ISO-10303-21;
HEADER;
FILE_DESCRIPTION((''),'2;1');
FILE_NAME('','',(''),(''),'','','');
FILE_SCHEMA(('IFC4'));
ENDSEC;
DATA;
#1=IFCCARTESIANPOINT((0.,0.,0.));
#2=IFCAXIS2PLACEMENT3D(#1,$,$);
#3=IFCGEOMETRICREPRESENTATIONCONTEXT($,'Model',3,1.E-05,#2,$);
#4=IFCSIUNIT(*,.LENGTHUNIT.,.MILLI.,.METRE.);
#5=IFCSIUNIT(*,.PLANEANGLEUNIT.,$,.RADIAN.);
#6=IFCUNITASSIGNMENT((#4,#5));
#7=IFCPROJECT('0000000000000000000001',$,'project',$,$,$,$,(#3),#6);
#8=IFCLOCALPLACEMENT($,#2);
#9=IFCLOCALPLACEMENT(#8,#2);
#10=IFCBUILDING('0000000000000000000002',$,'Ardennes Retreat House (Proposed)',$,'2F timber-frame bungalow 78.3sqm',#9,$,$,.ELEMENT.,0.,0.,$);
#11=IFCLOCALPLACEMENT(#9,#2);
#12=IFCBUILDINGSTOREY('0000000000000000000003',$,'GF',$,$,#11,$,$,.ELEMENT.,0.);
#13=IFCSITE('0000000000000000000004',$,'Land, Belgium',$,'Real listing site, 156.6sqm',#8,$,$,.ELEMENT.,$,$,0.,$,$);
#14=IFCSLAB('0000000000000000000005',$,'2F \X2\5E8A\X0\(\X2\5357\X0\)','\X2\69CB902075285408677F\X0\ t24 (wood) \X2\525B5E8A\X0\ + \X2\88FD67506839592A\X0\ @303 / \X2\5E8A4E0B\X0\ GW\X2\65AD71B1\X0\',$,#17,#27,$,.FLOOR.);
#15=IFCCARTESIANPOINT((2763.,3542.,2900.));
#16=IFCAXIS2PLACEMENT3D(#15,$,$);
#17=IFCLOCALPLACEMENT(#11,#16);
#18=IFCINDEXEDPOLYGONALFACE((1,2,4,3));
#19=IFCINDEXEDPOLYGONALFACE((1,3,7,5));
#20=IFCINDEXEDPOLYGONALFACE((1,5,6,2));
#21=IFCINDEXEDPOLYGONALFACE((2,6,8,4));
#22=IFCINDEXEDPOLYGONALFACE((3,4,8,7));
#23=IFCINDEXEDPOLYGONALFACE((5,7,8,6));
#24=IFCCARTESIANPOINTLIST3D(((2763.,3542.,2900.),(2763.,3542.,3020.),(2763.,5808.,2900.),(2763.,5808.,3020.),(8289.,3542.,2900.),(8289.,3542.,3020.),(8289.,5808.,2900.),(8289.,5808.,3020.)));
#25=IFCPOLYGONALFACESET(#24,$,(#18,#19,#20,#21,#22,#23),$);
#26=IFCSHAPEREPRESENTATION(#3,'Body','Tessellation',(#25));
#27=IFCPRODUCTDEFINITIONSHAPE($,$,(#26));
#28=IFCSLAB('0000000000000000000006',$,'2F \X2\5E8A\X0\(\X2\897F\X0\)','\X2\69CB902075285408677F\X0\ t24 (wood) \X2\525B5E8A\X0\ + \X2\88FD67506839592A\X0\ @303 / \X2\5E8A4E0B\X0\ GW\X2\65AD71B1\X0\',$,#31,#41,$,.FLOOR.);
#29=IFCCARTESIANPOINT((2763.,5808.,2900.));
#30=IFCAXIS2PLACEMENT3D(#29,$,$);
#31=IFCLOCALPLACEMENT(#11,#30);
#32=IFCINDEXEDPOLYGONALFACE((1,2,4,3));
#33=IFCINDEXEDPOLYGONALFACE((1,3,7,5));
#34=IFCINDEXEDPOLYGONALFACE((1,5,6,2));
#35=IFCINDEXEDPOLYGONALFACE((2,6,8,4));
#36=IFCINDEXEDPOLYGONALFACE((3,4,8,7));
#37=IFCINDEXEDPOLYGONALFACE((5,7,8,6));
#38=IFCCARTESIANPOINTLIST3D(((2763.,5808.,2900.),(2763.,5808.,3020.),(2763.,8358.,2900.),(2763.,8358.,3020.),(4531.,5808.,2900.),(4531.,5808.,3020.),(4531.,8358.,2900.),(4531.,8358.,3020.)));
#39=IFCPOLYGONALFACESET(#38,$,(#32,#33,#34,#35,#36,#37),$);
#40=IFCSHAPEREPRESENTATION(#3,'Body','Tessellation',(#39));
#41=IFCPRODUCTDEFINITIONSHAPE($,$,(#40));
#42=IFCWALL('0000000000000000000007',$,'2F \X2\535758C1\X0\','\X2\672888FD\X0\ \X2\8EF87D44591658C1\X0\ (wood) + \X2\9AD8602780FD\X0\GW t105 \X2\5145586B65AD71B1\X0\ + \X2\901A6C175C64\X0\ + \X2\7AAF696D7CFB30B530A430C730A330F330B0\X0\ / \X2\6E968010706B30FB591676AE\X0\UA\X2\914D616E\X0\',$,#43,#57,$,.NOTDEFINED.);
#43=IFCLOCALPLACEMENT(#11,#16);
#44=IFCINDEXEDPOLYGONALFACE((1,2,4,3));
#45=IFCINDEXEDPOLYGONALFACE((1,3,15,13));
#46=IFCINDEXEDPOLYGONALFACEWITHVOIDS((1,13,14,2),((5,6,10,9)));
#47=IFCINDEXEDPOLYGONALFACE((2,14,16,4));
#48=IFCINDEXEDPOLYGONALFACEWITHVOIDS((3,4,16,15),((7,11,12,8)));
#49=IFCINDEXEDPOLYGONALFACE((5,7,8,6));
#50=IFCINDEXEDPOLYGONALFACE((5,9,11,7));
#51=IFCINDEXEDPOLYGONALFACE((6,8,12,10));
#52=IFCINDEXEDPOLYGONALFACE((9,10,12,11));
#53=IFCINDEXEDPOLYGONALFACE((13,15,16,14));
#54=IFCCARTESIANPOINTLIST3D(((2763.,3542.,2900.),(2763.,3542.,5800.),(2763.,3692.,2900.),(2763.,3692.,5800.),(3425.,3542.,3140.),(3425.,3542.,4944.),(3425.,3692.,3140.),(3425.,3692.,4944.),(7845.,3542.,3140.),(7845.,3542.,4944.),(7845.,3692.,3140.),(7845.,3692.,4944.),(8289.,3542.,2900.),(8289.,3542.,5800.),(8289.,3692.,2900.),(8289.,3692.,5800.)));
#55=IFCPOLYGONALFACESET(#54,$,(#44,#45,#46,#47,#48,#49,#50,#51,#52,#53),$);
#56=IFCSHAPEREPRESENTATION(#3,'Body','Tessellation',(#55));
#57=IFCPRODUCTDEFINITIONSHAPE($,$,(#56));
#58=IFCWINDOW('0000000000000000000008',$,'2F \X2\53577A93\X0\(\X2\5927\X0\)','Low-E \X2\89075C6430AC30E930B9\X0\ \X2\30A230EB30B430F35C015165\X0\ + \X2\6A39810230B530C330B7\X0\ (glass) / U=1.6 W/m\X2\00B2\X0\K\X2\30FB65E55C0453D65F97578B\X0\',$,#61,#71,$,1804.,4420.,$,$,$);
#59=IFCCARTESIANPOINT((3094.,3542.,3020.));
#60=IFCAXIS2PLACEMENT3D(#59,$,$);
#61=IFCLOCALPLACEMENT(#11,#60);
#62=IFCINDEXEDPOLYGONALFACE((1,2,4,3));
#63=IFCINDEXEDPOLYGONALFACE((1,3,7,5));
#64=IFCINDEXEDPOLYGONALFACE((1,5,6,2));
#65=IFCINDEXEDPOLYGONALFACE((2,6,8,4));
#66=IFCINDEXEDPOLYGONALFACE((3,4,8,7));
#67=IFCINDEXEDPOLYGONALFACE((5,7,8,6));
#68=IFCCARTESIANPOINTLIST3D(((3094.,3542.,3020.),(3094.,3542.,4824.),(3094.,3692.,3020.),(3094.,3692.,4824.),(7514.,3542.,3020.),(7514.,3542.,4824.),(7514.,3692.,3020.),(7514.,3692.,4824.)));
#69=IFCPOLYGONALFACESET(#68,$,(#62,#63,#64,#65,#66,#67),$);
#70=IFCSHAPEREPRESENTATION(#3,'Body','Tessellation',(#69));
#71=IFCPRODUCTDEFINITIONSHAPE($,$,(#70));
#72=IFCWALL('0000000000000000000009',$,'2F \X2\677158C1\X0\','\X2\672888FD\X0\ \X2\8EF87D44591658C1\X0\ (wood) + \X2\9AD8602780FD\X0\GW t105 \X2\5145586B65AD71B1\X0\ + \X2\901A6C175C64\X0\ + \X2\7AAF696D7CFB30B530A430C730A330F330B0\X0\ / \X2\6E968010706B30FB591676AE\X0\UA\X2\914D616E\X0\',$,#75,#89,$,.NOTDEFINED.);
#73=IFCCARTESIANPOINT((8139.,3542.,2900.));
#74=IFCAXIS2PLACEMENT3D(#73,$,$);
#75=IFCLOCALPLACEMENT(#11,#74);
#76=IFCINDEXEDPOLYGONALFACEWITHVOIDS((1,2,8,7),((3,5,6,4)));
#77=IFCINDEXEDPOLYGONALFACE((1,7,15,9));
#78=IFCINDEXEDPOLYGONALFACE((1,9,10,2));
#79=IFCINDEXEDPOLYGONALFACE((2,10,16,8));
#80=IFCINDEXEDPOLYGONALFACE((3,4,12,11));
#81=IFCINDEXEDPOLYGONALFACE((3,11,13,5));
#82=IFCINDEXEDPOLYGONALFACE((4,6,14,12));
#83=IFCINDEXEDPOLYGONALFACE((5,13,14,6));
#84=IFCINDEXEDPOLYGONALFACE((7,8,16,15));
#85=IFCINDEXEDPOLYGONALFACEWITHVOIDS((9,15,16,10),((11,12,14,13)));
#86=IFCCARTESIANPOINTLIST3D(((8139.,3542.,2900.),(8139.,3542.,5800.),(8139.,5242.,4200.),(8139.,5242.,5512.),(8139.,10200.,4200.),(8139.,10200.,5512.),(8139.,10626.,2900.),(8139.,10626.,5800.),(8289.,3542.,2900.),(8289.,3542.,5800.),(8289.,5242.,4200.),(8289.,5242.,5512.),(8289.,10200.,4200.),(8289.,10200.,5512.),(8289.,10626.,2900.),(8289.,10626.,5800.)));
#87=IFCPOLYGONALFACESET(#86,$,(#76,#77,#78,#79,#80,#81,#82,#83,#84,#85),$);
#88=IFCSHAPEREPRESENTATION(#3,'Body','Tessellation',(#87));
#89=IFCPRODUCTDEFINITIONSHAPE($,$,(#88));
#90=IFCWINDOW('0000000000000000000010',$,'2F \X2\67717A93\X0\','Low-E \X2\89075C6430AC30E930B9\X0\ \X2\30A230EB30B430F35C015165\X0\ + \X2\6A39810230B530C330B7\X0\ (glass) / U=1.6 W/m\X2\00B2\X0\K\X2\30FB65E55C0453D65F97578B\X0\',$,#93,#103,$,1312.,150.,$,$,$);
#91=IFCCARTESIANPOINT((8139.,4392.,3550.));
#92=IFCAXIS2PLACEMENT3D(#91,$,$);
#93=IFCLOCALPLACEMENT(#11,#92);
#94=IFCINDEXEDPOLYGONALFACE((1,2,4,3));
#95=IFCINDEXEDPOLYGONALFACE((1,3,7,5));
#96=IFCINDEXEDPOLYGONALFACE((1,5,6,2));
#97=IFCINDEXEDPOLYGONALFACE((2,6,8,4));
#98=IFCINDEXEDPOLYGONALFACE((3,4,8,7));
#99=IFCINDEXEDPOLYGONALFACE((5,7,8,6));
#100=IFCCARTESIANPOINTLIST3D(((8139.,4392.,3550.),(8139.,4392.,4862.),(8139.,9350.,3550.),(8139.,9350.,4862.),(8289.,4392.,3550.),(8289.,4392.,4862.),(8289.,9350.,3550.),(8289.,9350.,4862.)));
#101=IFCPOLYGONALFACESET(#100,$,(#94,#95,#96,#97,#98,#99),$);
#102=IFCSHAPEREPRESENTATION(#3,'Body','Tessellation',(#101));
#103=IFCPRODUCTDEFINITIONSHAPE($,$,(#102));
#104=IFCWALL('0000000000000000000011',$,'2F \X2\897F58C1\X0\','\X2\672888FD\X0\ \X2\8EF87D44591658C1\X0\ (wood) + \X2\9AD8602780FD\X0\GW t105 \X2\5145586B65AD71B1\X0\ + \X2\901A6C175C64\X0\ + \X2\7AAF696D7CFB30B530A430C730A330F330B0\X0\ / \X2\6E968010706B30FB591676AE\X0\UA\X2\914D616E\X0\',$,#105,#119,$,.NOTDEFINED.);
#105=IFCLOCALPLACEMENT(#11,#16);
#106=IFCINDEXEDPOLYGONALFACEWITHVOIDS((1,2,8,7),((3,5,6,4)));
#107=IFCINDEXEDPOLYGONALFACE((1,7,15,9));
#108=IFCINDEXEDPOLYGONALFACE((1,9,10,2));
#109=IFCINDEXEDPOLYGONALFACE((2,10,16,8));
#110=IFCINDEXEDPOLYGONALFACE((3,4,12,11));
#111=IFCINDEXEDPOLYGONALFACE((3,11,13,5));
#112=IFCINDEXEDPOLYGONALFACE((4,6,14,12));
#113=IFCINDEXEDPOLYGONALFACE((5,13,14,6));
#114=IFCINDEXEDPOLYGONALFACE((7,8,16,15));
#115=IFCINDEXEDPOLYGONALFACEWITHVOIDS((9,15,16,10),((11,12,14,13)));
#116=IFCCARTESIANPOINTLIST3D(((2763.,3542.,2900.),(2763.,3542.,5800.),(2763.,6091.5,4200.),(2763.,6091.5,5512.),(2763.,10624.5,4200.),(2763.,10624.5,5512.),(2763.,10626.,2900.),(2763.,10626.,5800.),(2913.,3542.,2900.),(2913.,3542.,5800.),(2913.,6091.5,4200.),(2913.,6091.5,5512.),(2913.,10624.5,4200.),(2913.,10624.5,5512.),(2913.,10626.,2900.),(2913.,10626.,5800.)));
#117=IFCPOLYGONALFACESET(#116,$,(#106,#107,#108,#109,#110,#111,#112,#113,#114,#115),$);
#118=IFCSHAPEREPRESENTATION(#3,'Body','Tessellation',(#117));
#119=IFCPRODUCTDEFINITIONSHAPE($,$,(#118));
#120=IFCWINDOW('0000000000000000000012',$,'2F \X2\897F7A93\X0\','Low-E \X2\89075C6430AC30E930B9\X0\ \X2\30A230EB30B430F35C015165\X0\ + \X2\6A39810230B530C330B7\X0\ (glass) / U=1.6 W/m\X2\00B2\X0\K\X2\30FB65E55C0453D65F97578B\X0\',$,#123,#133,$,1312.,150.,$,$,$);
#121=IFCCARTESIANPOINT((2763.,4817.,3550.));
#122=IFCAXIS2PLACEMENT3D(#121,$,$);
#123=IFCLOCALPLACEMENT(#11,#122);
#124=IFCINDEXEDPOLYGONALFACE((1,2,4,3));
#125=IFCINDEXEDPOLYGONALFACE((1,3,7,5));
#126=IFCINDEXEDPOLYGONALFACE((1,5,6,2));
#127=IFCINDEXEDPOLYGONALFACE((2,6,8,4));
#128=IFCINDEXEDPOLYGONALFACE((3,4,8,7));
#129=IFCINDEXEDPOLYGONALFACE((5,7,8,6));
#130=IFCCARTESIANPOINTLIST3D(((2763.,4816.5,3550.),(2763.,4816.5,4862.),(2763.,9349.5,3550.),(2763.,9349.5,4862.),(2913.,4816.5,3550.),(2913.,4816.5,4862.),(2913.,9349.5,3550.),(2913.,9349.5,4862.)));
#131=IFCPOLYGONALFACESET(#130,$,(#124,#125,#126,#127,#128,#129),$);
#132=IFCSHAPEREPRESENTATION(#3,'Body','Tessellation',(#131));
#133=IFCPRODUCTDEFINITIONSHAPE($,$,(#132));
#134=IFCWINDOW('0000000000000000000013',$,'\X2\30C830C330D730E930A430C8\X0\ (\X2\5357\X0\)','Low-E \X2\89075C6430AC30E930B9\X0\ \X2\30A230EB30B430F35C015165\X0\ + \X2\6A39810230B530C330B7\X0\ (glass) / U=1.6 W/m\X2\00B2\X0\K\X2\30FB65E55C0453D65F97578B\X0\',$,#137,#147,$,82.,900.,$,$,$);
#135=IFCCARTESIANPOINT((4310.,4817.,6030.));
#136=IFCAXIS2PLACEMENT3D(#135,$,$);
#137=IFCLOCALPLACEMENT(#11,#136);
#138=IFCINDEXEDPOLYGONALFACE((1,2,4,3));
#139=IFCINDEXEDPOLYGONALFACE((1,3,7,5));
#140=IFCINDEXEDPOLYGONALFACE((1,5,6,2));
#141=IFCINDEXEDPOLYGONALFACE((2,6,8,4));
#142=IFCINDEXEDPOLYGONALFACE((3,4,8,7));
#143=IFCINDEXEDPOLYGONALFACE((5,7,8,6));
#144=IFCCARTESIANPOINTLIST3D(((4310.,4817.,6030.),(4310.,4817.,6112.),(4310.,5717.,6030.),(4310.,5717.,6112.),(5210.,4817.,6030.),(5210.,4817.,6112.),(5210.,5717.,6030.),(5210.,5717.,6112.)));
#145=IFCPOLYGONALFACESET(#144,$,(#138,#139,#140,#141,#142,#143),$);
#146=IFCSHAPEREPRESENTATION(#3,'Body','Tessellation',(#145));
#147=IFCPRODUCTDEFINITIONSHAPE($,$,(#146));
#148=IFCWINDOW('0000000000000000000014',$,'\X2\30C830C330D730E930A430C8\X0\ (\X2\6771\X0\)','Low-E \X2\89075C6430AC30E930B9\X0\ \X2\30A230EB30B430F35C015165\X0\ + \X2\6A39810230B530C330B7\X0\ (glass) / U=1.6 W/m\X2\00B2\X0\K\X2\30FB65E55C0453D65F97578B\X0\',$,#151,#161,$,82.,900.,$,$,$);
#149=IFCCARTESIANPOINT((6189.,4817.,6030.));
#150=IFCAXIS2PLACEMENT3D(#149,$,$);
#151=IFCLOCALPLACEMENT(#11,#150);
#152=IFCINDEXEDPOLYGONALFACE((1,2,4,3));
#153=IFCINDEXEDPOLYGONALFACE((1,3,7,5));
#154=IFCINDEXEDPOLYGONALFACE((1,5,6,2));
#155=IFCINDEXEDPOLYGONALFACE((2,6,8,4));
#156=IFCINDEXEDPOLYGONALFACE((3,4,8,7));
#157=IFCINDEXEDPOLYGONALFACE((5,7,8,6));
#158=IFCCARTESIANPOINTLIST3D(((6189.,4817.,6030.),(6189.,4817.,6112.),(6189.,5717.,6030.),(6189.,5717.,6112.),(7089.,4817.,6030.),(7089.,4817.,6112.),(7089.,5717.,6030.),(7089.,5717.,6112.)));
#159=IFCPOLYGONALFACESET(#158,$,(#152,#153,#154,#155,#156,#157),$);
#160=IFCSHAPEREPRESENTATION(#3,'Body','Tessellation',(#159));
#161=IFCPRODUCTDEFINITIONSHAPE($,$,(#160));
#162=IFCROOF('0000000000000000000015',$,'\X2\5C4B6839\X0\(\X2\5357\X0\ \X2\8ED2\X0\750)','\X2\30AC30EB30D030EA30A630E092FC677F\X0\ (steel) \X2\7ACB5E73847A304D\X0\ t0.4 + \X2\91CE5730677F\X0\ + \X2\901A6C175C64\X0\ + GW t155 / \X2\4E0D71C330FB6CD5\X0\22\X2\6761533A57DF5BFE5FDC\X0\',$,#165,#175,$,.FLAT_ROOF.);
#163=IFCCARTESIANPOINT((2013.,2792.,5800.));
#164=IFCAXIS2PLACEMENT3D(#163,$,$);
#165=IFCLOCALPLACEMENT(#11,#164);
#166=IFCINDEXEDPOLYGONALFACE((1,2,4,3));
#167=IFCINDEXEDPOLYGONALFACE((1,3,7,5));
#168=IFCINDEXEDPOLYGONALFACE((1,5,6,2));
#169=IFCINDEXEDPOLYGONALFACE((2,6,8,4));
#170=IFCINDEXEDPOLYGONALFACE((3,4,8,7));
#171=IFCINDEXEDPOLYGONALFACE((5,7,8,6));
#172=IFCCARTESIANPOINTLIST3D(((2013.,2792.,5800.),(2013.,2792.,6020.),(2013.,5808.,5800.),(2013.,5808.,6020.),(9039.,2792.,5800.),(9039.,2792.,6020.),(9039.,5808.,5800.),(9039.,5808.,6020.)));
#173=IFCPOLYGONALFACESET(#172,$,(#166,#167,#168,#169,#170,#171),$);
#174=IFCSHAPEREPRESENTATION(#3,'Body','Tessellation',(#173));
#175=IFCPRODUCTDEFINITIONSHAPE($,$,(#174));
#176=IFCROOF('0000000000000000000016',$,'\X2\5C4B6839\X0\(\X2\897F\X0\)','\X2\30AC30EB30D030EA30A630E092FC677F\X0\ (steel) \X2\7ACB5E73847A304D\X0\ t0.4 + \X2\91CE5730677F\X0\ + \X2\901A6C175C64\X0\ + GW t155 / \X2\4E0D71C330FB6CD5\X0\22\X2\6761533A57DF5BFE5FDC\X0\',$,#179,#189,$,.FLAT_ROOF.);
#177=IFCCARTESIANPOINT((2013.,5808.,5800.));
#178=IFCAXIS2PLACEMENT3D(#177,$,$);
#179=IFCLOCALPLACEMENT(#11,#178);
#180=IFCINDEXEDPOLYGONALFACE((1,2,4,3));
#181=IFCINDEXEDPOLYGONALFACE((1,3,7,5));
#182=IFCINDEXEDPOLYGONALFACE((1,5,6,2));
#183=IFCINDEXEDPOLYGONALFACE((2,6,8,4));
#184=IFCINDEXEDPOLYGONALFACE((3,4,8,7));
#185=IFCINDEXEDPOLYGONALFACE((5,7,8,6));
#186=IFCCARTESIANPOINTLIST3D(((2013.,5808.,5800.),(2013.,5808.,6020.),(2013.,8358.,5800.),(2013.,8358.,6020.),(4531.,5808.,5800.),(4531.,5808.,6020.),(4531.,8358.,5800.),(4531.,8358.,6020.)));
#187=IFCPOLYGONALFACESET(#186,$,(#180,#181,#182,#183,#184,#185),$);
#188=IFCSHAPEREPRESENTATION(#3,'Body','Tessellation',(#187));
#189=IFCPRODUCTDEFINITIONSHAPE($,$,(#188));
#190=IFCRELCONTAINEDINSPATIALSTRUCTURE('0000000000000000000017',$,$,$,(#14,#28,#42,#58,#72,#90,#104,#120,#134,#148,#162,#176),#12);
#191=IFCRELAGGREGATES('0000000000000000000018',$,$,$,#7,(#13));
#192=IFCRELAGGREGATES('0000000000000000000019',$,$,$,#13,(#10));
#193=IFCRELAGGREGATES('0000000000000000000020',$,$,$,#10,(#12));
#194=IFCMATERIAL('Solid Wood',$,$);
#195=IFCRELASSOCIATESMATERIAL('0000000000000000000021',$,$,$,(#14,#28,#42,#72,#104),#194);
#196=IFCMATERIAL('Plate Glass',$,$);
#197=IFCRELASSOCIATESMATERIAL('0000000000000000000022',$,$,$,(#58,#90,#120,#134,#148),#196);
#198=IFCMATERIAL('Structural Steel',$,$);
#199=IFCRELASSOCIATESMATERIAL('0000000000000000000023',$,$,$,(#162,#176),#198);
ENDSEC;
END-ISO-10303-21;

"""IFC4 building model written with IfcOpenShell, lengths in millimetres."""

from ifc_helpers import new_model, si_unit, frame, frame_2d, origin, place, context, project, spatial, rectangle, extrude, material, element, fill, save


model = new_model("IFC4")

# Units and contexts
model_context = context("Model", 3, precision=1e-05, world=origin())
ifc_project = project(units=[si_unit("LENGTHUNIT", "METRE", prefix="MILLI"), si_unit("PLANEANGLEUNIT", "RADIAN")], contexts=[model_context])

# Site, building, storey
site_placement = place(None, origin())
site = spatial("IfcSite", under=ifc_project, at=site_placement, Name="Land, Belgium", ObjectType="Real listing site, 156.6sqm", CompositionType="ELEMENT", RefElevation=0.0)
building_placement = place(site_placement, origin())
building = spatial("IfcBuilding", under=site, at=building_placement, Name="Ardennes Retreat House (Proposed)", ObjectType="2F timber-frame bungalow 78.3sqm", CompositionType="ELEMENT", ElevationOfRefHeight=0.0, ElevationOfTerrain=0.0)
storey_placement = place(building_placement, origin())
storey = spatial("IfcBuildingStorey", under=building, at=storey_placement, Name="GF", CompositionType="ELEMENT", Elevation=0.0)

# Slabs
ifc_material_1 = material(Name="Solid Wood")
slab_1_placement = place(storey_placement, frame((2763.0, 3542.0, 2900.0)))
element("IfcSlab", 1, at=slab_1_placement, inside=storey, material=ifc_material_1, Name="2F 床(南)", Description="構造用合板 t24 (wood) 剛床 + 製材根太 @303 / 床下 GW断熱", PredefinedType="FLOOR", context=model_context, shape_type="SweptSolid", body=[
    extrude(rectangle(XDim=5526.0, YDim=2266.0, at=frame_2d((2763.0, 1133.0))), frame((2763.0, 3542.0, 2900.0)), (0.0, 0.0, 1.0), 120.0),
])
slab_2_placement = place(storey_placement, frame((2763.0, 5808.0, 2900.0)))
element("IfcSlab", 2, at=slab_2_placement, inside=storey, material=ifc_material_1, Name="2F 床(西)", Description="構造用合板 t24 (wood) 剛床 + 製材根太 @303 / 床下 GW断熱", PredefinedType="FLOOR", context=model_context, shape_type="SweptSolid", body=[
    extrude(rectangle(XDim=1768.0, YDim=2550.0, at=frame_2d((884.0, 1275.0))), frame((2763.0, 5808.0, 2900.0)), (0.0, 0.0, 1.0), 120.0),
])

# Walls, openings, windows
wall_1_placement = place(storey_placement, frame((2763.0, 3542.0, 2900.0)))
wall_1 = element("IfcWall", 3, at=wall_1_placement, inside=storey, material=ifc_material_1, Name="2F 南壁", Description="木製 軸組外壁 (wood) + 高性能GW t105 充填断熱 + 通気層 + 窯業系サイディング / 準耐火・外皮UA配慮", PredefinedType="NOTDEFINED", context=model_context, shape_type="SweptSolid", body=[
    extrude(rectangle(XDim=5526.0, YDim=150.0, at=frame_2d((2763.0, 75.0))), frame((2763.0, 3542.0, 2900.0)), (0.0, 0.0, 1.0), 2900.0),
])
opening_1_placement = place(storey_placement, frame((3094.0, 3542.0, 3020.0)))
opening_1 = element("IfcOpeningElement", 4, at=opening_1_placement, cuts=wall_1, PredefinedType="NOTDEFINED", context=model_context, shape_type="SweptSolid", body=[
    extrude(rectangle(XDim=4420.0, YDim=150.0, at=frame_2d((2210.0, 75.0))), frame((3094.0, 3542.0, 3020.0)), (0.0, 0.0, 1.0), 1804.0),
])
ifc_material_2 = material(Name="Plate Glass")
window_1_placement = place(storey_placement, frame((3094.0, 3542.0, 3020.0)))
window_1 = element("IfcWindow", 5, at=window_1_placement, inside=storey, material=ifc_material_2, Name="2F 南窓(大)", Description="Low-E 複層ガラス アルゴン封入 + 樹脂サッシ (glass) / U=1.6 W/m²K・日射取得型", OverallHeight=1804.0, OverallWidth=4420.0, context=model_context, shape_type="SweptSolid", body=[
    extrude(rectangle(XDim=4420.0, YDim=150.0, at=frame_2d((2210.0, 75.0))), frame((3094.0, 3542.0, 3020.0)), (0.0, 0.0, 1.0), 1804.0),
])
fill(opening_1, window_1)
wall_2_placement = place(storey_placement, frame((8139.0, 3542.0, 2900.0)))
wall_2 = element("IfcWall", 6, at=wall_2_placement, inside=storey, material=ifc_material_1, Name="2F 東壁", Description="木製 軸組外壁 (wood) + 高性能GW t105 充填断熱 + 通気層 + 窯業系サイディング / 準耐火・外皮UA配慮", PredefinedType="NOTDEFINED", context=model_context, shape_type="SweptSolid", body=[
    extrude(rectangle(XDim=150.0, YDim=7084.0, at=frame_2d((75.0, 3542.0))), frame((8139.0, 3542.0, 2900.0)), (0.0, 0.0, 1.0), 2900.0),
])
opening_2_placement = place(storey_placement, frame((8139.0, 4392.0, 3550.0)))
opening_2 = element("IfcOpeningElement", 7, at=opening_2_placement, cuts=wall_2, PredefinedType="NOTDEFINED", context=model_context, shape_type="SweptSolid", body=[
    extrude(rectangle(XDim=150.0, YDim=4958.0, at=frame_2d((75.0, 2479.0))), frame((8139.0, 4392.0, 3550.0)), (0.0, 0.0, 1.0), 1312.0),
])
window_2_placement = place(storey_placement, frame((8139.0, 4392.0, 3550.0)))
window_2 = element("IfcWindow", 8, at=window_2_placement, inside=storey, material=ifc_material_2, Name="2F 東窓", Description="Low-E 複層ガラス アルゴン封入 + 樹脂サッシ (glass) / U=1.6 W/m²K・日射取得型", OverallHeight=1312.0, OverallWidth=150.0, context=model_context, shape_type="SweptSolid", body=[
    extrude(rectangle(XDim=150.0, YDim=4958.0, at=frame_2d((75.0, 2479.0))), frame((8139.0, 4392.0, 3550.0)), (0.0, 0.0, 1.0), 1312.0),
])
fill(opening_2, window_2)
wall_3_placement = place(storey_placement, frame((2763.0, 3542.0, 2900.0)))
wall_3 = element("IfcWall", 9, at=wall_3_placement, inside=storey, material=ifc_material_1, Name="2F 西壁", Description="木製 軸組外壁 (wood) + 高性能GW t105 充填断熱 + 通気層 + 窯業系サイディング / 準耐火・外皮UA配慮", PredefinedType="NOTDEFINED", context=model_context, shape_type="SweptSolid", body=[
    extrude(rectangle(XDim=150.0, YDim=7084.0, at=frame_2d((75.0, 3542.0))), frame((2763.0, 3542.0, 2900.0)), (0.0, 0.0, 1.0), 2900.0),
])
opening_3_placement = place(storey_placement, frame((2763.0, 4817.0, 3550.0)))
opening_3 = element("IfcOpeningElement", 10, at=opening_3_placement, cuts=wall_3, PredefinedType="NOTDEFINED", context=model_context, shape_type="SweptSolid", body=[
    extrude(rectangle(XDim=150.0, YDim=4533.0, at=frame_2d((75.0, 2266.0))), frame((2763.0, 4817.0, 3550.0)), (0.0, 0.0, 1.0), 1312.0),
])
window_3_placement = place(storey_placement, frame((2763.0, 4817.0, 3550.0)))
window_3 = element("IfcWindow", 11, at=window_3_placement, inside=storey, material=ifc_material_2, Name="2F 西窓", Description="Low-E 複層ガラス アルゴン封入 + 樹脂サッシ (glass) / U=1.6 W/m²K・日射取得型", OverallHeight=1312.0, OverallWidth=150.0, context=model_context, shape_type="SweptSolid", body=[
    extrude(rectangle(XDim=150.0, YDim=4533.0, at=frame_2d((75.0, 2266.0))), frame((2763.0, 4817.0, 3550.0)), (0.0, 0.0, 1.0), 1312.0),
])
fill(opening_3, window_3)

# Windows
window_4_placement = place(storey_placement, frame((4310.0, 4817.0, 6030.0)))
element("IfcWindow", 12, at=window_4_placement, inside=storey, material=ifc_material_2, Name="トップライト (南)", Description="Low-E 複層ガラス アルゴン封入 + 樹脂サッシ (glass) / U=1.6 W/m²K・日射取得型", OverallHeight=82.0, OverallWidth=900.0, context=model_context, shape_type="SweptSolid", body=[
    extrude(rectangle(XDim=900.0, YDim=900.0, at=frame_2d((450.0, 450.0))), frame((4310.0, 4817.0, 6030.0)), (0.0, 0.0, 1.0), 82.0),
])
window_5_placement = place(storey_placement, frame((6189.0, 4817.0, 6030.0)))
element("IfcWindow", 13, at=window_5_placement, inside=storey, material=ifc_material_2, Name="トップライト (東)", Description="Low-E 複層ガラス アルゴン封入 + 樹脂サッシ (glass) / U=1.6 W/m²K・日射取得型", OverallHeight=82.0, OverallWidth=900.0, context=model_context, shape_type="SweptSolid", body=[
    extrude(rectangle(XDim=900.0, YDim=900.0, at=frame_2d((450.0, 450.0))), frame((6189.0, 4817.0, 6030.0)), (0.0, 0.0, 1.0), 82.0),
])

# Roofs
ifc_material_3 = material(Name="Structural Steel")
roof_1_placement = place(storey_placement, frame((2013.0, 2792.0, 5800.0)))
element("IfcRoof", 14, at=roof_1_placement, inside=storey, material=ifc_material_3, Name="屋根(南 軒750)", Description="ガルバリウム鋼板 (steel) 立平葺き t0.4 + 野地板 + 通気層 + GW t155 / 不燃・法22条区域対応", PredefinedType="FLAT_ROOF", context=model_context, shape_type="SweptSolid", body=[
    extrude(rectangle(XDim=7026.0, YDim=3016.0, at=frame_2d((3513.0, 1508.0))), frame((2013.0, 2792.0, 5800.0)), (0.0, 0.0, 1.0), 220.0),
])
roof_2_placement = place(storey_placement, frame((2013.0, 5808.0, 5800.0)))
element("IfcRoof", 15, at=roof_2_placement, inside=storey, material=ifc_material_3, Name="屋根(西)", Description="ガルバリウム鋼板 (steel) 立平葺き t0.4 + 野地板 + 通気層 + GW t155 / 不燃・法22条区域対応", PredefinedType="FLAT_ROOF", context=model_context, shape_type="SweptSolid", body=[
    extrude(rectangle(XDim=2518.0, YDim=2550.0, at=frame_2d((1259.0, 1275.0))), frame((2013.0, 5808.0, 5800.0)), (0.0, 0.0, 1.0), 220.0),
])

save(model, "model.ifc")
